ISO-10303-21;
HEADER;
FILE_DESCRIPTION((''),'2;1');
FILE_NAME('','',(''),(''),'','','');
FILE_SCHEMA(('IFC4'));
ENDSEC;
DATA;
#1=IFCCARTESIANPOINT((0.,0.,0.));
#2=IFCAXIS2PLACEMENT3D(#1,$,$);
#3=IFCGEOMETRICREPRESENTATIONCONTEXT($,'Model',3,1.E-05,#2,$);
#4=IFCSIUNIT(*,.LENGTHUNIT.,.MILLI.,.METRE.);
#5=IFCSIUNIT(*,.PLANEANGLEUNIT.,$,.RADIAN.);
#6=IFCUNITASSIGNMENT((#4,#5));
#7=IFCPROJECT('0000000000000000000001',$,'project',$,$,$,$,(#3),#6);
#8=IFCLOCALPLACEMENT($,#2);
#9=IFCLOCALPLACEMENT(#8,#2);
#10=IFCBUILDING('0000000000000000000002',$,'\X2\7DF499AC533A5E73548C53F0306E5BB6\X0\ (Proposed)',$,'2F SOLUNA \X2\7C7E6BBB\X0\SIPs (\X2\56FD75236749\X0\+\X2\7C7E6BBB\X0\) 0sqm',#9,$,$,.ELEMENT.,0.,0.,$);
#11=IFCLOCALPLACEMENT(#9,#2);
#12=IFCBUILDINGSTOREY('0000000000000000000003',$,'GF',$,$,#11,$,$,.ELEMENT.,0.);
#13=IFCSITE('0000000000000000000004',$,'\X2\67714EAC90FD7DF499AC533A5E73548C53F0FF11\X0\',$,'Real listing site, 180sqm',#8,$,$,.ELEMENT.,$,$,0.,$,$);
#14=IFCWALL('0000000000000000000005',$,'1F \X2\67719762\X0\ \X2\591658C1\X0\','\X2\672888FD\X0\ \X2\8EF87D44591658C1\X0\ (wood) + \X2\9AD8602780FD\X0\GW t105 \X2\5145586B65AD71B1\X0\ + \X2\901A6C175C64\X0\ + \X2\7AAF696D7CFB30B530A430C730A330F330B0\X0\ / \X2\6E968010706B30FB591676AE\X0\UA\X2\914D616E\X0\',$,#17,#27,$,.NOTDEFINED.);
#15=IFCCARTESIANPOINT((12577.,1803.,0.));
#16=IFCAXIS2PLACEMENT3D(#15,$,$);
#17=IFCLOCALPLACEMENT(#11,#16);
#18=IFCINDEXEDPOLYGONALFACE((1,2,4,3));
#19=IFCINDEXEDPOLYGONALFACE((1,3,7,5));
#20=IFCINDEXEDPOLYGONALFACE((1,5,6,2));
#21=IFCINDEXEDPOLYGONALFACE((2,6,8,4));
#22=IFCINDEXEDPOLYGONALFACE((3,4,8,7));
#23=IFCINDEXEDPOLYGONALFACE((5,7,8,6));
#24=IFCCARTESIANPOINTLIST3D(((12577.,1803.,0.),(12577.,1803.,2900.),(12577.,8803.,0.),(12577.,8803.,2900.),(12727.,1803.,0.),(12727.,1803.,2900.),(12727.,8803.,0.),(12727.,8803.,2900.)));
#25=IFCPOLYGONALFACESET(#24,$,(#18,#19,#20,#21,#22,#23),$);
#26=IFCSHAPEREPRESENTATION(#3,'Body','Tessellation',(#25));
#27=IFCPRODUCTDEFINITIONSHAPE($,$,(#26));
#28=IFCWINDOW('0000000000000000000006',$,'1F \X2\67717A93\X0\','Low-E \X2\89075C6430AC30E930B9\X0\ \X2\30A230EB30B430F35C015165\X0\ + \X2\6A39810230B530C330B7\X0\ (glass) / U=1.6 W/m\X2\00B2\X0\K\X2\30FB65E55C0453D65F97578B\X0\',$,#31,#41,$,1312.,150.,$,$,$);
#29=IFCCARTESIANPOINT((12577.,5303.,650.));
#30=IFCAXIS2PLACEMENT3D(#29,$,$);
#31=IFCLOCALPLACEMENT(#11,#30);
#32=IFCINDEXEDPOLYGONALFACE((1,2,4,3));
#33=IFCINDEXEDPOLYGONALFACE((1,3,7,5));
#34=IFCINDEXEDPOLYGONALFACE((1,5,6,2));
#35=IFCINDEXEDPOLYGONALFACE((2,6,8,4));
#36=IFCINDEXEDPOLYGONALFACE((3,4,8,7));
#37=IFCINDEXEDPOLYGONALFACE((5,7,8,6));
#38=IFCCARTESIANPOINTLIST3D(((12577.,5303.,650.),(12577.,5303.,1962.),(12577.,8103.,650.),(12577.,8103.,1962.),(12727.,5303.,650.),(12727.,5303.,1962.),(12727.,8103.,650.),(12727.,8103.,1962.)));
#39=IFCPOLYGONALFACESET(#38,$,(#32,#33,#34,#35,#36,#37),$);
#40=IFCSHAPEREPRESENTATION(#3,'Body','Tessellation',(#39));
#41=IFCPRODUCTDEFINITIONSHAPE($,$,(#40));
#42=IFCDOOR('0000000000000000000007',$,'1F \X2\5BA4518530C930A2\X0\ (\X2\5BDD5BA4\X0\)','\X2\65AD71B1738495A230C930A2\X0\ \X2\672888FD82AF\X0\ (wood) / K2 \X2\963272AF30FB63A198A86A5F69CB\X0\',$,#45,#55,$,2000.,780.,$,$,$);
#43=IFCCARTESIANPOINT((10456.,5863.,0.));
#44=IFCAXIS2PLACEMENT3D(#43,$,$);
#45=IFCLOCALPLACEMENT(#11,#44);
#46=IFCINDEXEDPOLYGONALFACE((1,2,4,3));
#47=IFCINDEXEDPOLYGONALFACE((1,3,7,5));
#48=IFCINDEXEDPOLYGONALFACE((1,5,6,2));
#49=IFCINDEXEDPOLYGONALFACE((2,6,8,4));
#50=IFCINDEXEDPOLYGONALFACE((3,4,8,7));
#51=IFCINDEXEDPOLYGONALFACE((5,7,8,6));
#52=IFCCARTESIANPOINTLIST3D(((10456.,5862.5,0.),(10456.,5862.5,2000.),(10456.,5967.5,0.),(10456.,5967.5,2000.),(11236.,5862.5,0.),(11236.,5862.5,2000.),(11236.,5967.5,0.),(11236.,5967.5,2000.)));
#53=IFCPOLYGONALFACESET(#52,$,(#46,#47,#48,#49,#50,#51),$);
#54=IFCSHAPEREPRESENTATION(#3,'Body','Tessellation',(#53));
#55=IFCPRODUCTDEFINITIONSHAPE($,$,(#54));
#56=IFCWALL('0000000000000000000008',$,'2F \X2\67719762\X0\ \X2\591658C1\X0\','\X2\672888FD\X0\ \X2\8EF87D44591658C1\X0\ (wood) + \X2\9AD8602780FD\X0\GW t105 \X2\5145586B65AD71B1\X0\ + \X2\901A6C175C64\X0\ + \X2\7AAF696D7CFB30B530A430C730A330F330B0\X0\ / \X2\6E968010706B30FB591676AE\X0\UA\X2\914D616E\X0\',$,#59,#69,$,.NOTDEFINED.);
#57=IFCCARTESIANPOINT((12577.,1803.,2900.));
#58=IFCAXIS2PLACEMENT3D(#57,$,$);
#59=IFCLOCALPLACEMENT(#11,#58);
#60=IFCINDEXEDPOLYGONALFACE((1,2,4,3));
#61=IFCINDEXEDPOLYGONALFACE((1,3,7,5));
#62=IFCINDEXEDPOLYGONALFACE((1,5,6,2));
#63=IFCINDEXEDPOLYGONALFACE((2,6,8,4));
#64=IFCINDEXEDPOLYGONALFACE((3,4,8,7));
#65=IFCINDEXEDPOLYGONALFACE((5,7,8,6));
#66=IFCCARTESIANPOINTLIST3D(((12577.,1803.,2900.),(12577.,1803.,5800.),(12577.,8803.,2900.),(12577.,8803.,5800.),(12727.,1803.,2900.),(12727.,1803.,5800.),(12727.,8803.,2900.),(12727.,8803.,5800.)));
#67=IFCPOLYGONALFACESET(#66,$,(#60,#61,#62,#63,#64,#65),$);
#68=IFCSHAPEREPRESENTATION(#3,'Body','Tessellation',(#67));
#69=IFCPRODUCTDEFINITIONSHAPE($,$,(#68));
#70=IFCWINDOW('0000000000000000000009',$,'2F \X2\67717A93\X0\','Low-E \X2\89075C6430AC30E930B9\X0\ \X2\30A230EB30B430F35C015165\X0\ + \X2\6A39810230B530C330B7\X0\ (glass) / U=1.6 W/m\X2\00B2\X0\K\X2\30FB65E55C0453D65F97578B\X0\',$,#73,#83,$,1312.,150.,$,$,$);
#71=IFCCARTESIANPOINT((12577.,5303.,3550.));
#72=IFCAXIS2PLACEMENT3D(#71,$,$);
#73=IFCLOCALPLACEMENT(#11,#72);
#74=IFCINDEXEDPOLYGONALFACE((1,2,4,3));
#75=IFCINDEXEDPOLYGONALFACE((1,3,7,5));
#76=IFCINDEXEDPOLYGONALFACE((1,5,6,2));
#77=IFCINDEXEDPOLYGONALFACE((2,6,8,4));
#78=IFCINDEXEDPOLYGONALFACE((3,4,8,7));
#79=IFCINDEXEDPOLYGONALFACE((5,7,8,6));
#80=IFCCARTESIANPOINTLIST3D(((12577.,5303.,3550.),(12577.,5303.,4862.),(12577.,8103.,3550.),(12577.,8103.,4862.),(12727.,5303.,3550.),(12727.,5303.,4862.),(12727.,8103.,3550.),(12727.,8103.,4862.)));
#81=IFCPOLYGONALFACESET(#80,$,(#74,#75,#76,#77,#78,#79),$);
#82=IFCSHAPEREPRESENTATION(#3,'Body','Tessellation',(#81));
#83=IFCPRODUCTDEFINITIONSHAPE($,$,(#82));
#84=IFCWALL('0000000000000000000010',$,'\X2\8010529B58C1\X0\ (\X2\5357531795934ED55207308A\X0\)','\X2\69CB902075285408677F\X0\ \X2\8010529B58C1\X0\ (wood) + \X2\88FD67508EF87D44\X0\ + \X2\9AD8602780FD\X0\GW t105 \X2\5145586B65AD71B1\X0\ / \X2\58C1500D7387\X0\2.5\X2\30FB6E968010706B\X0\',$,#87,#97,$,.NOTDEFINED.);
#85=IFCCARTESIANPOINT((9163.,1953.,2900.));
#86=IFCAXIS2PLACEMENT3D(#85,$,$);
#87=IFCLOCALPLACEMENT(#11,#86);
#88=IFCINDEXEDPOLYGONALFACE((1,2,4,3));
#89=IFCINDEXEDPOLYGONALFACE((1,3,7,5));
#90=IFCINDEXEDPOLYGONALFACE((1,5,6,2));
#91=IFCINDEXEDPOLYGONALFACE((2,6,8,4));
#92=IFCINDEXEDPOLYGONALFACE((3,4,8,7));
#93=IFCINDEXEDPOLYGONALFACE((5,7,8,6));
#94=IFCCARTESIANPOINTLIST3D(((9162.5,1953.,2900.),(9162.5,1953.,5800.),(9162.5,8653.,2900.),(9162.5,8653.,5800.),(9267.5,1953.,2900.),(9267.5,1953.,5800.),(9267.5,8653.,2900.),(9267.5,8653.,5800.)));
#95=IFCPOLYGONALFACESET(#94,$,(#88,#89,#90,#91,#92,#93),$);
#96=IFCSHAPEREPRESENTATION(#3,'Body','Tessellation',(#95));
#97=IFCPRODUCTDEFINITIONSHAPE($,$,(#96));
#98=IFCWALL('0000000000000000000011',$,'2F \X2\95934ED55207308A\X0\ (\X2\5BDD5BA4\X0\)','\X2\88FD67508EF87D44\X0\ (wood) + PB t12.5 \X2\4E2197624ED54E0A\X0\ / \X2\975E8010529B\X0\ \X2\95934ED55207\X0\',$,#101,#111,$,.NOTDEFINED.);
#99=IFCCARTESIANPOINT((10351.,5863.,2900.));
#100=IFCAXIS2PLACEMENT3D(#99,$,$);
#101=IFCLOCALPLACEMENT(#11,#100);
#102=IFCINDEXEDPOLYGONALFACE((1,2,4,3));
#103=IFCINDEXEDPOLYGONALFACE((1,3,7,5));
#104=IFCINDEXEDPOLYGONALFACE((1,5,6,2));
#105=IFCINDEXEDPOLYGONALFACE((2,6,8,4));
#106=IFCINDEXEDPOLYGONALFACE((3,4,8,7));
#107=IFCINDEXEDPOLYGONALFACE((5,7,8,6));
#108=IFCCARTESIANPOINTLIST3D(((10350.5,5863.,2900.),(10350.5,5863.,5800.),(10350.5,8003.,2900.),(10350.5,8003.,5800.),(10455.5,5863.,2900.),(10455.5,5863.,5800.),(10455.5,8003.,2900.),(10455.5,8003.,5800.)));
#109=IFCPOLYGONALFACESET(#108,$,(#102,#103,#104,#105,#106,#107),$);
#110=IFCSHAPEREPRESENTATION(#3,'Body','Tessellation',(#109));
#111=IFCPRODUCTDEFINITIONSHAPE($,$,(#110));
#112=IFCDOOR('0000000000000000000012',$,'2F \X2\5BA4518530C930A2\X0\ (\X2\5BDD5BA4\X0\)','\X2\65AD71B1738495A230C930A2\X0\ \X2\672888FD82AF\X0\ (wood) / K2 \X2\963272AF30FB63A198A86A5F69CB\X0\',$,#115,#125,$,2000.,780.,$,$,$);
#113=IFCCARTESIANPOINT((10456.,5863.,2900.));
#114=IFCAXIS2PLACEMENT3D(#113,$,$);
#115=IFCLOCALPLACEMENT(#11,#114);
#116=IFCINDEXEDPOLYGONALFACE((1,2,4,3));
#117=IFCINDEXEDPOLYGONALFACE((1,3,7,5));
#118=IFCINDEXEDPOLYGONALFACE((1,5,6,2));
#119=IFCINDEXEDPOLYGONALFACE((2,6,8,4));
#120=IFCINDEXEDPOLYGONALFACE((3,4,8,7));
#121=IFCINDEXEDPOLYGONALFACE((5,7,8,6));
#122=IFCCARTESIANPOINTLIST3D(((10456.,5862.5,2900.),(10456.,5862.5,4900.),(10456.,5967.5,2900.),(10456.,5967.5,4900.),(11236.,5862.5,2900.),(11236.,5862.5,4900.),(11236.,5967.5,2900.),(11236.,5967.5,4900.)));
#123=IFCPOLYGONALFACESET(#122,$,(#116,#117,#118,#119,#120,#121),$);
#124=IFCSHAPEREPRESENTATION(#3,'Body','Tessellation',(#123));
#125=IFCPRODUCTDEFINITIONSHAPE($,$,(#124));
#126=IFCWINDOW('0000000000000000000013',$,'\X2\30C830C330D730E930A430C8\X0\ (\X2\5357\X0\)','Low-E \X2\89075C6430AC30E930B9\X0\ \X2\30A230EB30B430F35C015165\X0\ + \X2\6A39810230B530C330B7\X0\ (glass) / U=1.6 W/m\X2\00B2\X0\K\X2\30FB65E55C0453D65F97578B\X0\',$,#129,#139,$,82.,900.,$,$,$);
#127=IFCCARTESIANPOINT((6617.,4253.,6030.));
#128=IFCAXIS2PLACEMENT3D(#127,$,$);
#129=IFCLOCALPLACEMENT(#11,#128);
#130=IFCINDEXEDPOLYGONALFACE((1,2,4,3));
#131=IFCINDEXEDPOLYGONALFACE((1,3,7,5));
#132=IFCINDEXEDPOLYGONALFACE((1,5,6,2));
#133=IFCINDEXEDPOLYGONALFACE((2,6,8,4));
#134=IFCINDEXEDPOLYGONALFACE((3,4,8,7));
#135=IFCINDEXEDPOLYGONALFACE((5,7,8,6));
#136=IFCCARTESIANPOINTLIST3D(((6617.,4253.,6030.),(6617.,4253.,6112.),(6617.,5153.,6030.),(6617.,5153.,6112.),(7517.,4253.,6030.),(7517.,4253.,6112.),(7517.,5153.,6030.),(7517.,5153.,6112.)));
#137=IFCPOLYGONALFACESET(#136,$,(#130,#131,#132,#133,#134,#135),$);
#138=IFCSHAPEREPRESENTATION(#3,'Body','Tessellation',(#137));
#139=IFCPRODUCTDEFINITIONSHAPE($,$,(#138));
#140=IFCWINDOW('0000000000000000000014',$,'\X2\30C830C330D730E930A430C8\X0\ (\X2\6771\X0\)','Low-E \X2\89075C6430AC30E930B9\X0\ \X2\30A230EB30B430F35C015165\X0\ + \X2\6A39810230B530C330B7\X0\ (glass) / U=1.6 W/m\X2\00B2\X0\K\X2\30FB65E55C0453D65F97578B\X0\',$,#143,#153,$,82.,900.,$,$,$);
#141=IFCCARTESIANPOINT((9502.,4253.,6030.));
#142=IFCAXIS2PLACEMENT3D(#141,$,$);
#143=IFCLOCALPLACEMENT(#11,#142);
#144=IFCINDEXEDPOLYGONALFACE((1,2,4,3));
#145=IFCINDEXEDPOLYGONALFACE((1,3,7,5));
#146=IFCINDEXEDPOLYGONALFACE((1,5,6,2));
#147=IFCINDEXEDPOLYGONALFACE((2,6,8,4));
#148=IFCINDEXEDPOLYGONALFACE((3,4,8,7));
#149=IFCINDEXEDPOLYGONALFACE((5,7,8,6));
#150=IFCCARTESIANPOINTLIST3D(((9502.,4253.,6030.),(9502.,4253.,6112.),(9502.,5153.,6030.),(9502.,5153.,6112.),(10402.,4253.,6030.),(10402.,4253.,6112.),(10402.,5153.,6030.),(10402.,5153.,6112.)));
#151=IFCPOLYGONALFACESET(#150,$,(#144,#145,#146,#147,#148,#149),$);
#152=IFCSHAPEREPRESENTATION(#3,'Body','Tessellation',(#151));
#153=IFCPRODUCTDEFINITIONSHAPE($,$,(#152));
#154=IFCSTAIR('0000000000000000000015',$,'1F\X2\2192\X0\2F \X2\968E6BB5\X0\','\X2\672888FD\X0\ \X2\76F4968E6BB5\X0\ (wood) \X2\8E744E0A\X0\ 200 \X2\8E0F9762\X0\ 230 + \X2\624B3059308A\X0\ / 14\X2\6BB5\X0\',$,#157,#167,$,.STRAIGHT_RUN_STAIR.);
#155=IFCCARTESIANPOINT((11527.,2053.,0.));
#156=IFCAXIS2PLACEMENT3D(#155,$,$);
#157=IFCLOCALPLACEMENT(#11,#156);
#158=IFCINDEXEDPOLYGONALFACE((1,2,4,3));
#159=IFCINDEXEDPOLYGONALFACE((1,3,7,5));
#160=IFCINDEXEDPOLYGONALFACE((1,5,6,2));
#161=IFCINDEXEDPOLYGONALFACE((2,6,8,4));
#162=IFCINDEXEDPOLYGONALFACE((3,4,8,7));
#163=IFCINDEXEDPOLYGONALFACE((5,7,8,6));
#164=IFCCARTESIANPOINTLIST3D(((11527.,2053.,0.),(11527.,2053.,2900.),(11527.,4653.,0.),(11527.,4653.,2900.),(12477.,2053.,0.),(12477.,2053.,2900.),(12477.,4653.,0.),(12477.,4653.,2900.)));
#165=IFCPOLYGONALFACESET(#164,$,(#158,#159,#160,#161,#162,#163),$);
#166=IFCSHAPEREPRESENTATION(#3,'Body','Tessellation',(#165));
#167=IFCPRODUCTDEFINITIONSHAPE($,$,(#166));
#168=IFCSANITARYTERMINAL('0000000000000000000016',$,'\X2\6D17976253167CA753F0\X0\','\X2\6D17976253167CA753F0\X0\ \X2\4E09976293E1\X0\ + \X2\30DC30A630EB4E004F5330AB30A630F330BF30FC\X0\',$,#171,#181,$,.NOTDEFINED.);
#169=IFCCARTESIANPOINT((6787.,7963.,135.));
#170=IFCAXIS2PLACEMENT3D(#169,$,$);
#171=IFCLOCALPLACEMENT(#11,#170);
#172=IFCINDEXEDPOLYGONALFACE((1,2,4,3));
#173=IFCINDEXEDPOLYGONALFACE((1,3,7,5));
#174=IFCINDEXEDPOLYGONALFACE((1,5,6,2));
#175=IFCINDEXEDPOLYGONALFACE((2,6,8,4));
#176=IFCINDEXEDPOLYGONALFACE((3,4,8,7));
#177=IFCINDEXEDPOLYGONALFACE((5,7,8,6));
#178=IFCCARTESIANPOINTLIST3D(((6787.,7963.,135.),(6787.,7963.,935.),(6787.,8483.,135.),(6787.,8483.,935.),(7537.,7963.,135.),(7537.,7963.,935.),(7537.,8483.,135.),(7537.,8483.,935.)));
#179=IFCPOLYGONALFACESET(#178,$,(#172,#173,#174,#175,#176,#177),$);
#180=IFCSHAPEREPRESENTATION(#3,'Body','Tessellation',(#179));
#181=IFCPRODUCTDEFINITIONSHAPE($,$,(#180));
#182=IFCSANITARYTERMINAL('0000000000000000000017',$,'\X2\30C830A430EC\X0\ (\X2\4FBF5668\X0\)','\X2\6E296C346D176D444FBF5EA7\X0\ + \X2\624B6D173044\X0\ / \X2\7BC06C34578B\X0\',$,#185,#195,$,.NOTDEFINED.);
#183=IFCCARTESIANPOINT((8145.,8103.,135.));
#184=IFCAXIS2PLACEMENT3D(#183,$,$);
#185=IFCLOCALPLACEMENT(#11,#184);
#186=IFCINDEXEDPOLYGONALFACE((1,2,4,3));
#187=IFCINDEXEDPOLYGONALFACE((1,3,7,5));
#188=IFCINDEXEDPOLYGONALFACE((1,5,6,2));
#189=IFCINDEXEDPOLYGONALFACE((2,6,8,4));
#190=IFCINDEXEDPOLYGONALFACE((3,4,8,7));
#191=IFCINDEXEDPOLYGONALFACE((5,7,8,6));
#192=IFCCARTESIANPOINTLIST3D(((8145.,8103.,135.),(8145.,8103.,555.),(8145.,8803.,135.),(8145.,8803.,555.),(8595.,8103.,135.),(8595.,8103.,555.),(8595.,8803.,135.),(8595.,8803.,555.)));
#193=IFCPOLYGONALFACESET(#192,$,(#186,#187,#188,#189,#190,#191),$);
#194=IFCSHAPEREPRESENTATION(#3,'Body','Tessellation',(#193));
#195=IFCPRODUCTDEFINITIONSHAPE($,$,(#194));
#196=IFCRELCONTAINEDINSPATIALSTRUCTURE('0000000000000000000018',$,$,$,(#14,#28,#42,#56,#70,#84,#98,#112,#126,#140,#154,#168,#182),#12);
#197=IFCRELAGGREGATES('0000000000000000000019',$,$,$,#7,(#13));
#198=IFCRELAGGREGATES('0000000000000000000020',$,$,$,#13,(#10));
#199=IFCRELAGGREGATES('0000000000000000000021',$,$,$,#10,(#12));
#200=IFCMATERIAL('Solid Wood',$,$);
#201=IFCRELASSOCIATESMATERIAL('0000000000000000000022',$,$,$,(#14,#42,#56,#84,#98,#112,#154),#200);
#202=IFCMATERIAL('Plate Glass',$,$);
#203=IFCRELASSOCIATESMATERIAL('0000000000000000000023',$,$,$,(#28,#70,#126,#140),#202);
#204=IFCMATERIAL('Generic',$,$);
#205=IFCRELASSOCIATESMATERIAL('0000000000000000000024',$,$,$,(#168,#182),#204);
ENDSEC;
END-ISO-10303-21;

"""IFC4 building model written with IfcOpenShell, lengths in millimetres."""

from ifc_helpers import new_model, si_unit, frame, frame_2d, origin, place, context, project, spatial, rectangle, extrude, material, element, fill, save


model = new_model("IFC4")

# Units and contexts
model_context = context("Model", 3, precision=1e-05, world=origin())
ifc_project = project(units=[si_unit("LENGTHUNIT", "METRE", prefix="MILLI"), si_unit("PLANEANGLEUNIT", "RADIAN")], contexts=[model_context])

# Site, building, storey
site_placement = place(None, origin())
site = spatial("IfcSite", under=ifc_project, at=site_placement, Name="東京都練馬区平和台１", ObjectType="Real listing site, 180sqm", CompositionType="ELEMENT", RefElevation=0.0)
building_placement = place(site_placement, origin())
building = spatial("IfcBuilding", under=site, at=building_placement, Name="練馬区平和台の家 (Proposed)", ObjectType="2F SOLUNA 籾殻SIPs (国産杉+籾殻) 0sqm", CompositionType="ELEMENT", ElevationOfRefHeight=0.0, ElevationOfTerrain=0.0)
storey_placement = place(building_placement, origin())
storey = spatial("IfcBuildingStorey", under=building, at=storey_placement, Name="GF", CompositionType="ELEMENT", Elevation=0.0)

# Wall, opening, window
ifc_material_1 = material(Name="Solid Wood")
wall_1_placement = place(storey_placement, frame((12577.0, 1803.0, 0.0)))
wall_1 = element("IfcWall", 1, at=wall_1_placement, inside=storey, material=ifc_material_1, Name="1F 東面 外壁", Description="木製 軸組外壁 (wood) + 高性能GW t105 充填断熱 + 通気層 + 窯業系サイディング / 準耐火・外皮UA配慮", PredefinedType="NOTDEFINED", context=model_context, shape_type="SweptSolid", body=[
    extrude(rectangle(XDim=150.0, YDim=7000.0, at=frame_2d((75.0, 3500.0))), frame((12577.0, 1803.0, 0.0)), (0.0, 0.0, 1.0), 2900.0),
])
opening_1_placement = place(storey_placement, frame((12577.0, 5303.0, 650.0)))
opening_1 = element("IfcOpeningElement", 2, at=opening_1_placement, cuts=wall_1, PredefinedType="NOTDEFINED", context=model_context, shape_type="SweptSolid", body=[
    extrude(rectangle(XDim=150.0, YDim=2800.0, at=frame_2d((75.0, 1400.0))), frame((12577.0, 5303.0, 650.0)), (0.0, 0.0, 1.0), 1312.0),
])
ifc_material_2 = material(Name="Plate Glass")
window_1_placement = place(storey_placement, frame((12577.0, 5303.0, 650.0)))
window_1 = element("IfcWindow", 3, at=window_1_placement, inside=storey, material=ifc_material_2, Name="1F 東窓", Description="Low-E 複層ガラス アルゴン封入 + 樹脂サッシ (glass) / U=1.6 W/m²K・日射取得型", OverallHeight=1312.0, OverallWidth=150.0, context=model_context, shape_type="SweptSolid", body=[
    extrude(rectangle(XDim=150.0, YDim=2800.0, at=frame_2d((75.0, 1400.0))), frame((12577.0, 5303.0, 650.0)), (0.0, 0.0, 1.0), 1312.0),
])
fill(opening_1, window_1)

# Door
door_1_placement = place(storey_placement, frame((10456.0, 5863.0, 0.0)))
element("IfcDoor", 4, at=door_1_placement, inside=storey, material=ifc_material_1, Name="1F 室内ドア (寝室)", Description="断熱玄関ドア 木製芯 (wood) / K2 防犯・採風機構", OverallHeight=2000.0, OverallWidth=780.0, context=model_context, shape_type="SweptSolid", body=[
    extrude(rectangle(XDim=780.0, YDim=105.0, at=frame_2d((390.0, 52.0))), frame((10456.0, 5863.0, 0.0)), (0.0, 0.0, 1.0), 2000.0),
])

# Wall, opening, window
wall_2_placement = place(storey_placement, frame((12577.0, 1803.0, 2900.0)))
wall_2 = element("IfcWall", 5, at=wall_2_placement, inside=storey, material=ifc_material_1, Name="2F 東面 外壁", Description="木製 軸組外壁 (wood) + 高性能GW t105 充填断熱 + 通気層 + 窯業系サイディング / 準耐火・外皮UA配慮", PredefinedType="NOTDEFINED", context=model_context, shape_type="SweptSolid", body=[
    extrude(rectangle(XDim=150.0, YDim=7000.0, at=frame_2d((75.0, 3500.0))), frame((12577.0, 1803.0, 2900.0)), (0.0, 0.0, 1.0), 2900.0),
])
opening_2_placement = place(storey_placement, frame((12577.0, 5303.0, 3550.0)))
opening_2 = element("IfcOpeningElement", 6, at=opening_2_placement, cuts=wall_2, PredefinedType="NOTDEFINED", context=model_context, shape_type="SweptSolid", body=[
    extrude(rectangle(XDim=150.0, YDim=2800.0, at=frame_2d((75.0, 1400.0))), frame((12577.0, 5303.0, 3550.0)), (0.0, 0.0, 1.0), 1312.0),
])
window_2_placement = place(storey_placement, frame((12577.0, 5303.0, 3550.0)))
window_2 = element("IfcWindow", 7, at=window_2_placement, inside=storey, material=ifc_material_2, Name="2F 東窓", Description="Low-E 複層ガラス アルゴン封入 + 樹脂サッシ (glass) / U=1.6 W/m²K・日射取得型", OverallHeight=1312.0, OverallWidth=150.0, context=model_context, shape_type="SweptSolid", body=[
    extrude(rectangle(XDim=150.0, YDim=2800.0, at=frame_2d((75.0, 1400.0))), frame((12577.0, 5303.0, 3550.0)), (0.0, 0.0, 1.0), 1312.0),
])
fill(opening_2, window_2)

# Walls
wall_3_placement = place(storey_placement, frame((9163.0, 1953.0, 2900.0)))
element("IfcWall", 8, at=wall_3_placement, inside=storey, material=ifc_material_1, Name="耐力壁 (南北間仕切り)", Description="構造用合板 耐力壁 (wood) + 製材軸組 + 高性能GW t105 充填断熱 / 壁倍率2.5・準耐火", PredefinedType="NOTDEFINED", context=model_context, shape_type="SweptSolid", body=[
    extrude(rectangle(XDim=105.0, YDim=6700.0, at=frame_2d((52.0, 3350.0))), frame((9163.0, 1953.0, 2900.0)), (0.0, 0.0, 1.0), 2900.0),
])
wall_4_placement = place(storey_placement, frame((10351.0, 5863.0, 2900.0)))
element("IfcWall", 9, at=wall_4_placement, inside=storey, material=ifc_material_1, Name="2F 間仕切り (寝室)", Description="製材軸組 (wood) + PB t12.5 両面仕上 / 非耐力 間仕切", PredefinedType="NOTDEFINED", context=model_context, shape_type="SweptSolid", body=[
    extrude(rectangle(XDim=105.0, YDim=2140.0, at=frame_2d((52.0, 1070.0))), frame((10351.0, 5863.0, 2900.0)), (0.0, 0.0, 1.0), 2900.0),
])

# Door
door_2_placement = place(storey_placement, frame((10456.0, 5863.0, 2900.0)))
element("IfcDoor", 10, at=door_2_placement, inside=storey, material=ifc_material_1, Name="2F 室内ドア (寝室)", Description="断熱玄関ドア 木製芯 (wood) / K2 防犯・採風機構", OverallHeight=2000.0, OverallWidth=780.0, context=model_context, shape_type="SweptSolid", body=[
    extrude(rectangle(XDim=780.0, YDim=105.0, at=frame_2d((390.0, 52.0))), frame((10456.0, 5863.0, 2900.0)), (0.0, 0.0, 1.0), 2000.0),
])

# Windows
window_3_placement = place(storey_placement, frame((6617.0, 4253.0, 6030.0)))
element("IfcWindow", 11, at=window_3_placement, inside=storey, material=ifc_material_2, Name="トップライト (南)", Description="Low-E 複層ガラス アルゴン封入 + 樹脂サッシ (glass) / U=1.6 W/m²K・日射取得型", OverallHeight=82.0, OverallWidth=900.0, context=model_context, shape_type="SweptSolid", body=[
    extrude(rectangle(XDim=900.0, YDim=900.0, at=frame_2d((450.0, 450.0))), frame((6617.0, 4253.0, 6030.0)), (0.0, 0.0, 1.0), 82.0),
])
window_4_placement = place(storey_placement, frame((9502.0, 4253.0, 6030.0)))
element("IfcWindow", 12, at=window_4_placement, inside=storey, material=ifc_material_2, Name="トップライト (東)", Description="Low-E 複層ガラス アルゴン封入 + 樹脂サッシ (glass) / U=1.6 W/m²K・日射取得型", OverallHeight=82.0, OverallWidth=900.0, context=model_context, shape_type="SweptSolid", body=[
    extrude(rectangle(XDim=900.0, YDim=900.0, at=frame_2d((450.0, 450.0))), frame((9502.0, 4253.0, 6030.0)), (0.0, 0.0, 1.0), 82.0),
])

# Stair
stair_placement = place(storey_placement, frame((11527.0, 2053.0, 0.0)))
element("IfcStair", 13, at=stair_placement, inside=storey, material=ifc_material_1, Name="1F→2F 階段", Description="木製 直階段 (wood) 蹴上 200 踏面 230 + 手すり / 14段", PredefinedType="STRAIGHT_RUN_STAIR", context=model_context, shape_type="SweptSolid", body=[
    extrude(rectangle(XDim=950.0, YDim=2600.0, at=frame_2d((475.0, 1300.0))), frame((11527.0, 2053.0, 0.0)), (0.0, 0.0, 1.0), 2900.0),
])

# Sanitary terminals
ifc_material_3 = material(Name="Generic")
sanitary_terminal_1_placement = place(storey_placement, frame((6787.0, 7963.0, 135.0)))
element("IfcSanitaryTerminal", 14, at=sanitary_terminal_1_placement, inside=storey, material=ifc_material_3, Name="洗面化粧台", Description="洗面化粧台 三面鏡 + ボウル一体カウンター", PredefinedType="NOTDEFINED", context=model_context, shape_type="SweptSolid", body=[
    extrude(rectangle(XDim=750.0, YDim=520.0, at=frame_2d((375.0, 260.0))), frame((6787.0, 7963.0, 135.0)), (0.0, 0.0, 1.0), 800.0),
])
sanitary_terminal_2_placement = place(storey_placement, frame((8145.0, 8103.0, 135.0)))
element("IfcSanitaryTerminal", 15, at=sanitary_terminal_2_placement, inside=storey, material=ifc_material_3, Name="トイレ (便器)", Description="温水洗浄便座 + 手洗い / 節水型", PredefinedType="NOTDEFINED", context=model_context, shape_type="SweptSolid", body=[
    extrude(rectangle(XDim=450.0, YDim=700.0, at=frame_2d((225.0, 350.0))), frame((8145.0, 8103.0, 135.0)), (0.0, 0.0, 1.0), 420.0),
])

save(model, "model.ifc")
